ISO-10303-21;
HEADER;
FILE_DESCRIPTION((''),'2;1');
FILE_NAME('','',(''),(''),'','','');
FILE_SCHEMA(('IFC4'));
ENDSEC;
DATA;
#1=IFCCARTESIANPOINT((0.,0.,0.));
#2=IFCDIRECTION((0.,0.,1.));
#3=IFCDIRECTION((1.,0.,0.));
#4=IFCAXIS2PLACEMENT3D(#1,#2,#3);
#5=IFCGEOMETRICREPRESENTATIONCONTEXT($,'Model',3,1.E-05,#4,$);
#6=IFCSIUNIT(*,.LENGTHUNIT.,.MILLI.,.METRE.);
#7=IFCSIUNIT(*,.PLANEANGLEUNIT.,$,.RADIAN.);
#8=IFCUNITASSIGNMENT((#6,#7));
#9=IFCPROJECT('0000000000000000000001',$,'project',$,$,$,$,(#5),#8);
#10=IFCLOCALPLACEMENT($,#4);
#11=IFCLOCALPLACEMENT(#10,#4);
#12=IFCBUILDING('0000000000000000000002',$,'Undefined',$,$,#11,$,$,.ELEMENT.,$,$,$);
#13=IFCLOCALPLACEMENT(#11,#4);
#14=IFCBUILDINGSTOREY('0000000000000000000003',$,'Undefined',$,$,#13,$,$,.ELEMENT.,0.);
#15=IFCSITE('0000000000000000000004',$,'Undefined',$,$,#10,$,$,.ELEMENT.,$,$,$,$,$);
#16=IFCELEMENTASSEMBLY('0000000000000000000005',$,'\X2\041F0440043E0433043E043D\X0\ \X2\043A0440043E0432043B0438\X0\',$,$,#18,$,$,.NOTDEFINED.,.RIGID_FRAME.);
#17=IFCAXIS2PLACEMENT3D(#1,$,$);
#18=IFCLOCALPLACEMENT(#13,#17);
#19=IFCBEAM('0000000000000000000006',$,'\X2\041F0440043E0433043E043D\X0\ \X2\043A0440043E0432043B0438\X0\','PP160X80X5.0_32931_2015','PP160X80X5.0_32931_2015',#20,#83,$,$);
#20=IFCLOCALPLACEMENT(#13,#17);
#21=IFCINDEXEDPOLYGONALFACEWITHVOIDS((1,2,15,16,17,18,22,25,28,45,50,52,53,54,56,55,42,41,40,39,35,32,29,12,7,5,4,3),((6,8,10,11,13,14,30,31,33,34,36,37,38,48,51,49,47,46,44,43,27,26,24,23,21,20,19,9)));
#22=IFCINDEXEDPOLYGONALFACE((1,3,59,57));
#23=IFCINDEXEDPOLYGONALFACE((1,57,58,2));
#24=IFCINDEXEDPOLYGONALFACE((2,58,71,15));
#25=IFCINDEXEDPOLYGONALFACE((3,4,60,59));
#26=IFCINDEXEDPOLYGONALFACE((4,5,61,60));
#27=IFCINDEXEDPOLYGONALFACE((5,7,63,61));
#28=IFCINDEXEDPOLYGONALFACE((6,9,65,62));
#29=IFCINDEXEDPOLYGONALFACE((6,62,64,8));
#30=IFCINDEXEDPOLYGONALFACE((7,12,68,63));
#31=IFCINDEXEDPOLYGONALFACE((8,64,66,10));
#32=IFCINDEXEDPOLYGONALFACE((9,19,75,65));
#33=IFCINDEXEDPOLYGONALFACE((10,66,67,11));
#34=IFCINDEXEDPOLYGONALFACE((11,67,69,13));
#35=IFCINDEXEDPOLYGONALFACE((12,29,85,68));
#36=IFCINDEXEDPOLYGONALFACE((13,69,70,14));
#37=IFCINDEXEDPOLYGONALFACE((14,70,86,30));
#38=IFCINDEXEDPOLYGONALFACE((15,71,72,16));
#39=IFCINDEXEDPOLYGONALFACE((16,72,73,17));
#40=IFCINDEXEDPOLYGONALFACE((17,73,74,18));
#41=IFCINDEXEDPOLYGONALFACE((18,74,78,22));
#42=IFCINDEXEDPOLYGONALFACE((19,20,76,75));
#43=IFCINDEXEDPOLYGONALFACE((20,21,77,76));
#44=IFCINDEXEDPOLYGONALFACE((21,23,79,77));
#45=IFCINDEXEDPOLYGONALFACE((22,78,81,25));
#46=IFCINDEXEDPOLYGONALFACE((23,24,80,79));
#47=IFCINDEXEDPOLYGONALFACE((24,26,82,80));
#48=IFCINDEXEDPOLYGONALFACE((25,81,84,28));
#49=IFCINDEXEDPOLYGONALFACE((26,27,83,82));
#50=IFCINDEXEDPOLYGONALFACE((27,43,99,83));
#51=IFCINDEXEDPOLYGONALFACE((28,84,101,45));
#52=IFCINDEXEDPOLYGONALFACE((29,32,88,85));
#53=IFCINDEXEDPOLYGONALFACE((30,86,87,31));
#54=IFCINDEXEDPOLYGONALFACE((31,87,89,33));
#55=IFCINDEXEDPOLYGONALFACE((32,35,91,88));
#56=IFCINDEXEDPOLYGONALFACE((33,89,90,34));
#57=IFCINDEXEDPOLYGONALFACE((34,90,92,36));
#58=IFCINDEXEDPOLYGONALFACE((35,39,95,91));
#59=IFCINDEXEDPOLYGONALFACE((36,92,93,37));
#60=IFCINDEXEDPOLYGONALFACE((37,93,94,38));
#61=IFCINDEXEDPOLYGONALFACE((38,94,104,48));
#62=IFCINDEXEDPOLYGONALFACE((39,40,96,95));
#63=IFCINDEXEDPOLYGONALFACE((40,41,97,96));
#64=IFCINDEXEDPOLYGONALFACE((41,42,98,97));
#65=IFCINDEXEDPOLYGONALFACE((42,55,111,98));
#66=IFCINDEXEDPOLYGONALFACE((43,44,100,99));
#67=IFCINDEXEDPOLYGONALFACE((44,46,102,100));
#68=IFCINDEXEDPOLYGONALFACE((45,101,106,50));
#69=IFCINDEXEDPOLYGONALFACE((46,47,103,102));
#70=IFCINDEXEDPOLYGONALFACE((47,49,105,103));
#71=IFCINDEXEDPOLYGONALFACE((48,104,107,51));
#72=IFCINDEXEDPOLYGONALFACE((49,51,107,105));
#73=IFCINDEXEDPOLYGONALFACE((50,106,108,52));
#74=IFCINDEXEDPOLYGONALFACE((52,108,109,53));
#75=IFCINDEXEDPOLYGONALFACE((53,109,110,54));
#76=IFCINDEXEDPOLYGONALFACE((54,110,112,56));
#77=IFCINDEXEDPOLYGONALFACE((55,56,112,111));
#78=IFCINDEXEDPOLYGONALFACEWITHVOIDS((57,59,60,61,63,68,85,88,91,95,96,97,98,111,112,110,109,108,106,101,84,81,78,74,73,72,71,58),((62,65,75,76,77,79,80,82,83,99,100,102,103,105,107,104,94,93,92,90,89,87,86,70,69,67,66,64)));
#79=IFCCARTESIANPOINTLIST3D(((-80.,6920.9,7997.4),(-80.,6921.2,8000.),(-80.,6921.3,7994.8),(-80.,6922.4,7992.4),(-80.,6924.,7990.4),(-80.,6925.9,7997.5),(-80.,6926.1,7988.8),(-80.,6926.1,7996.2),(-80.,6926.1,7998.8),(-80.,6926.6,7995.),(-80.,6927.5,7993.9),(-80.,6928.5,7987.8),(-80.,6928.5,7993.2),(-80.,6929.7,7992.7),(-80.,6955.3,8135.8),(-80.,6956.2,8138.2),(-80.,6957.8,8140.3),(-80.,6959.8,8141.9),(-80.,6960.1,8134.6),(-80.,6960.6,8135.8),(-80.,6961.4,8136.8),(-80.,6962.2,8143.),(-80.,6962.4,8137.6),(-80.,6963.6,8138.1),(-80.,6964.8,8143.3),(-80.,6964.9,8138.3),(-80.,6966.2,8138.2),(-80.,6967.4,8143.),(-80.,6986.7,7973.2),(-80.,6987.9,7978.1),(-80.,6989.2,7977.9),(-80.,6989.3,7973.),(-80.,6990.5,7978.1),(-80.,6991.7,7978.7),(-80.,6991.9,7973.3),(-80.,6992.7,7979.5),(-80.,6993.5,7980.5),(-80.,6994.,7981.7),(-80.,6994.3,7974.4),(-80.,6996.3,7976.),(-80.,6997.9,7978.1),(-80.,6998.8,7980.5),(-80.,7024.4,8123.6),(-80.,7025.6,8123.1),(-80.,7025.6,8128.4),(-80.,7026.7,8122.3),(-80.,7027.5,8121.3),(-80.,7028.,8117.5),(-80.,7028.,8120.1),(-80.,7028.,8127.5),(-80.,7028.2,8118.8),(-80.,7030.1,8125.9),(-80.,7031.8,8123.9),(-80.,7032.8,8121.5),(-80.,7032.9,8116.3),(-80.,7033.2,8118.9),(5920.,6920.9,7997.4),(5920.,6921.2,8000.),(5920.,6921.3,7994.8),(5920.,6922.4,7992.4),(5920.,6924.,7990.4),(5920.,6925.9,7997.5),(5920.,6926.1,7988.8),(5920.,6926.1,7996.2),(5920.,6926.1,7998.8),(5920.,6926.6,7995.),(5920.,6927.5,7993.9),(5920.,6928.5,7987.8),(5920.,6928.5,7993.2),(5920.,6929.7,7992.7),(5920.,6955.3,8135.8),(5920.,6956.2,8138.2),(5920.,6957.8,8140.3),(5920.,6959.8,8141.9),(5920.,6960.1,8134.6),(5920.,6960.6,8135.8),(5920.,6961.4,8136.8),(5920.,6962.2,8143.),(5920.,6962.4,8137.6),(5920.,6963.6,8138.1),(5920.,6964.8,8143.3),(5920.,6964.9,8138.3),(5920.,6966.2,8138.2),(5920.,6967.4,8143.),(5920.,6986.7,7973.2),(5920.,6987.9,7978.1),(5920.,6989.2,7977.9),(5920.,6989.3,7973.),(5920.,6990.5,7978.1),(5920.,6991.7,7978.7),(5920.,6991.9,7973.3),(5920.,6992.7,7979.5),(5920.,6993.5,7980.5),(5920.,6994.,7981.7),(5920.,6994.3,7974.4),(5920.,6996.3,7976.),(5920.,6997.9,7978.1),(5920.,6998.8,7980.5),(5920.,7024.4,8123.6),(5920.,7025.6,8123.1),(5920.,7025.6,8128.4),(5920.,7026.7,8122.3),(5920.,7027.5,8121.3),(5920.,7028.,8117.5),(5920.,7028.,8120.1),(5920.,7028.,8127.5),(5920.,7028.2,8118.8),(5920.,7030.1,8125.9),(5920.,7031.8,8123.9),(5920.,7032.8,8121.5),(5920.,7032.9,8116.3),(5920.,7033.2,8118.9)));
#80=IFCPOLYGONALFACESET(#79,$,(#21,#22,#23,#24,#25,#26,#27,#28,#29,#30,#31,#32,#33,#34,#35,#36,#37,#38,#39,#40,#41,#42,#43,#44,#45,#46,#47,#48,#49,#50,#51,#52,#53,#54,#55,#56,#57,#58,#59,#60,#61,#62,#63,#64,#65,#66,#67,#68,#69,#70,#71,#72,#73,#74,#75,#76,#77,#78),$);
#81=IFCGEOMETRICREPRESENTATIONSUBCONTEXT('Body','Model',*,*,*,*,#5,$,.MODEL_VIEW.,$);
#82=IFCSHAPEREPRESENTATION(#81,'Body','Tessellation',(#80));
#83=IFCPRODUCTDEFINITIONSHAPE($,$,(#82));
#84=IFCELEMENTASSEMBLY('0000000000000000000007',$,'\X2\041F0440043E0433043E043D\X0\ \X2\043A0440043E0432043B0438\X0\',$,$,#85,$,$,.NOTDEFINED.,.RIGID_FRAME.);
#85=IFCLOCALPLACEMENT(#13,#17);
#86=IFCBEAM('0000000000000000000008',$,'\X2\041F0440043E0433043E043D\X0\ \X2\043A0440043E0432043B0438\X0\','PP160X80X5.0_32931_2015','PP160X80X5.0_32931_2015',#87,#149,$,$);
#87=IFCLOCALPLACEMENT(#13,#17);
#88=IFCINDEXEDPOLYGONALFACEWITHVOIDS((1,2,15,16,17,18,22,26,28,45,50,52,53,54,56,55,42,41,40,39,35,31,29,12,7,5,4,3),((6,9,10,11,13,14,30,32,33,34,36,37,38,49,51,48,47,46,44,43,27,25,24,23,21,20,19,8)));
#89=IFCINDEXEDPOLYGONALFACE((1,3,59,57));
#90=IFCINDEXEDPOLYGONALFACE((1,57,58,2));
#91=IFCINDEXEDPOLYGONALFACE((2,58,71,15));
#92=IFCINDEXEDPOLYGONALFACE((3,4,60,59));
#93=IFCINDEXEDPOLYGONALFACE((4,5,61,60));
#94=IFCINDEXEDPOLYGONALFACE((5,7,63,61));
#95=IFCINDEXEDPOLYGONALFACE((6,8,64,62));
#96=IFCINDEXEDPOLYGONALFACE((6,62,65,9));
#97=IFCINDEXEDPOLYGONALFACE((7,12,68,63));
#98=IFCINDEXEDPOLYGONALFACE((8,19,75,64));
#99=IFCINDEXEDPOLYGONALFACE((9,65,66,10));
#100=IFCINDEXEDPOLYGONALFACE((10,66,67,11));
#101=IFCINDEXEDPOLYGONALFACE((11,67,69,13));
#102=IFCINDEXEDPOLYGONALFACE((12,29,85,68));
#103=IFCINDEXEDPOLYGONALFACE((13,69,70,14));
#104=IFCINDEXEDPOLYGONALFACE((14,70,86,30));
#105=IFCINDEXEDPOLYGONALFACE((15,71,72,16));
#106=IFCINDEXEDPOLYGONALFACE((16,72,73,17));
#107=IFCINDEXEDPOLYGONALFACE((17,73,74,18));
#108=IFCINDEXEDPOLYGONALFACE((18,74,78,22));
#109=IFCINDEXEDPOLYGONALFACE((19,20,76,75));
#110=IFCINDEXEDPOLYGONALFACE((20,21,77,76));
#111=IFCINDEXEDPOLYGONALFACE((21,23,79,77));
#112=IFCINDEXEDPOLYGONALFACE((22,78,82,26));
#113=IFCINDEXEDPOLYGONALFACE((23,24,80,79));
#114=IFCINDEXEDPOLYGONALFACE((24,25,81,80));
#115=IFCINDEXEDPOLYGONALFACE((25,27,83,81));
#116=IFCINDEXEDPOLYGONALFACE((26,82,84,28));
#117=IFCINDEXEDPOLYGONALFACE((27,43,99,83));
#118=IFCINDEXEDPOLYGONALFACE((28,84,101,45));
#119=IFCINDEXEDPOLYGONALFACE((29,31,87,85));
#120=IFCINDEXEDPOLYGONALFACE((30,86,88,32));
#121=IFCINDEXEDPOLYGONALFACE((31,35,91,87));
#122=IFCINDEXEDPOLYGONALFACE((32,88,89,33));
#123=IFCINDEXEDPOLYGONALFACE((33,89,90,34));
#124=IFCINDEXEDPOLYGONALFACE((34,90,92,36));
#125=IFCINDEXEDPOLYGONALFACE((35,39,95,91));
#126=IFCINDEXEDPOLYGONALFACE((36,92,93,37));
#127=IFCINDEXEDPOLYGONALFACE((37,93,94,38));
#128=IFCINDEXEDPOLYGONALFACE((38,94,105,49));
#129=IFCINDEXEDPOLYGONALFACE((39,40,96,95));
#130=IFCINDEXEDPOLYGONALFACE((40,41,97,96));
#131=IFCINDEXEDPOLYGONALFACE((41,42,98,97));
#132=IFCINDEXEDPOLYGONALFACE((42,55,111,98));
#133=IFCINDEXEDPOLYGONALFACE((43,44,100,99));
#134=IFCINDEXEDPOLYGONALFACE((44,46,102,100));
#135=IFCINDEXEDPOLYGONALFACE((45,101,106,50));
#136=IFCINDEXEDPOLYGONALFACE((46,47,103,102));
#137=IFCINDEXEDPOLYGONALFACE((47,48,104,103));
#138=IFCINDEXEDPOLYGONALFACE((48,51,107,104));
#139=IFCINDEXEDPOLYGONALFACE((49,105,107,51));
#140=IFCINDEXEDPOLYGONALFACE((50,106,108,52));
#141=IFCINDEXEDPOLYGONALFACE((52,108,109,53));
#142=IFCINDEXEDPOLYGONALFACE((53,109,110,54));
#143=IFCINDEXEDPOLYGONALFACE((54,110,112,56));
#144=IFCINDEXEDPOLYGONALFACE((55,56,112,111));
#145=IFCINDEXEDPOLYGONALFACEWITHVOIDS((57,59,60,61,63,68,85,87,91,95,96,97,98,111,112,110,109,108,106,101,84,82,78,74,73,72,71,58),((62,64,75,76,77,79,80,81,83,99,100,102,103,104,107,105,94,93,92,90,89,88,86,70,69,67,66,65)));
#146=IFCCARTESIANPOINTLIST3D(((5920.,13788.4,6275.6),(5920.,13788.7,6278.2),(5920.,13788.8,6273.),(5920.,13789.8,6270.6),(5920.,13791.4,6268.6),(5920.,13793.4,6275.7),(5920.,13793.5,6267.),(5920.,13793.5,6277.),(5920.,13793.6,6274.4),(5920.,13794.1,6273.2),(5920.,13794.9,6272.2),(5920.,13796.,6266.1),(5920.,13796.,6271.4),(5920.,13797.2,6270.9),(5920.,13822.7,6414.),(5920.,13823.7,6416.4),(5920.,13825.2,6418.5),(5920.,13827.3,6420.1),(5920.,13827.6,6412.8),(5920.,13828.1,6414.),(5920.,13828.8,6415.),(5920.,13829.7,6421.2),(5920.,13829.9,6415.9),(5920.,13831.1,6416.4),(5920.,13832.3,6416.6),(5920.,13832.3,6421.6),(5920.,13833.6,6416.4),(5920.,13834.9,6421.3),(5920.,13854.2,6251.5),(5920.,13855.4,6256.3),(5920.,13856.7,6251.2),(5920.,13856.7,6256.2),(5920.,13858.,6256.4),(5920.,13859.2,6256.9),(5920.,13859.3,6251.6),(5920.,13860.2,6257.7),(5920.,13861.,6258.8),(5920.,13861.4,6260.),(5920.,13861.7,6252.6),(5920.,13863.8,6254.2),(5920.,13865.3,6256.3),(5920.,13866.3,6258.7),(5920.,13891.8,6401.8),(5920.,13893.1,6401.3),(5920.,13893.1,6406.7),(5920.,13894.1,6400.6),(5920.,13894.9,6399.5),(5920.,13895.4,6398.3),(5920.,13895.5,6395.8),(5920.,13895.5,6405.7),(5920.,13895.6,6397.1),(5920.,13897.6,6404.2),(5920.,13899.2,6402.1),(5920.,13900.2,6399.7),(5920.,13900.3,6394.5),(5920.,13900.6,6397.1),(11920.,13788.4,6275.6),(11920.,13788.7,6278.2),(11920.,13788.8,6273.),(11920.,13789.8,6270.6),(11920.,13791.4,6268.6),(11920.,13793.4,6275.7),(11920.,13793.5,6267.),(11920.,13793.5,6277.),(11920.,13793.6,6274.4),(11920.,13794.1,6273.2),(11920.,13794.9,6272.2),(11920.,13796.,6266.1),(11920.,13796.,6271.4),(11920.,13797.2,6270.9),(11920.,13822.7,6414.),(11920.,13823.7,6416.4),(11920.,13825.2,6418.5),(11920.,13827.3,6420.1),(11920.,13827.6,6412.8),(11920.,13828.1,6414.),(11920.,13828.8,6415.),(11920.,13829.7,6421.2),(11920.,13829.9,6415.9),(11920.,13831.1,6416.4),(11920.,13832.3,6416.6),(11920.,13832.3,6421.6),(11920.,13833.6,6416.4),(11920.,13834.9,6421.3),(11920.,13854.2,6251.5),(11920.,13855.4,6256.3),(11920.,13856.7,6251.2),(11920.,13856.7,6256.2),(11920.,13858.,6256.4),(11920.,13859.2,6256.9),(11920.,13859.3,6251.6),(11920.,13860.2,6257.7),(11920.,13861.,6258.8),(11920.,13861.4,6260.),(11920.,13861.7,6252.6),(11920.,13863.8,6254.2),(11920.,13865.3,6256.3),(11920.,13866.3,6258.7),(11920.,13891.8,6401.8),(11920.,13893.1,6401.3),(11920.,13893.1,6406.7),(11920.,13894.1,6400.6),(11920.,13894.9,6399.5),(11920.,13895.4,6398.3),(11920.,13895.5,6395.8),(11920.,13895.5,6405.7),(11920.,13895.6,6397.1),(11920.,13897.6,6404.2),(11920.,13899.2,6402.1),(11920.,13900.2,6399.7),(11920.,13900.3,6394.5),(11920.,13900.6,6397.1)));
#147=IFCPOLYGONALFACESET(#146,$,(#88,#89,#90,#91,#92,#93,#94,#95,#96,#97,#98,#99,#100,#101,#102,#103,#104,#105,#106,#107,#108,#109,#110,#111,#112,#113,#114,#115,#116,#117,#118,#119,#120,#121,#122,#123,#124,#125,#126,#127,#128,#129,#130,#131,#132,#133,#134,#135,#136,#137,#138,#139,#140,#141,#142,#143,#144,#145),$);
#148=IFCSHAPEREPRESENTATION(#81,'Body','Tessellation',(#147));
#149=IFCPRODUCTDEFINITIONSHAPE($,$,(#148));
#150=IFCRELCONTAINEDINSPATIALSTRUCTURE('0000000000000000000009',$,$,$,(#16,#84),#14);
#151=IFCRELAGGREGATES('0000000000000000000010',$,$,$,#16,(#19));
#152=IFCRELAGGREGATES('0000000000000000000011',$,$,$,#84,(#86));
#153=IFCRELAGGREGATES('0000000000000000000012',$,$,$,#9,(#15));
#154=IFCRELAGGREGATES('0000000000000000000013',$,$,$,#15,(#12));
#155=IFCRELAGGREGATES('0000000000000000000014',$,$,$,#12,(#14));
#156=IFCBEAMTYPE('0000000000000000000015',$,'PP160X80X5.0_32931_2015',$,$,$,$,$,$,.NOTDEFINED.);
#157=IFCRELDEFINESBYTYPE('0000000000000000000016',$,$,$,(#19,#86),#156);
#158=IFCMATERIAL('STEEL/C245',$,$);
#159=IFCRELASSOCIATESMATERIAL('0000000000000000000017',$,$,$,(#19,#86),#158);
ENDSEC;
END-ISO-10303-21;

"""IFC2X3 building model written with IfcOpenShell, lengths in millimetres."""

from ifc_helpers import new_model, si_unit, frame, origin_with_axes, origin_2d_with_axis, place, context, subcontext, project, spatial, hollow_rectangle, extrude, material, type_object, element, aggregate, save


model = new_model("IFC2X3")

# Units and contexts
model_context = context("Model", 3, precision=1e-05, world=origin_with_axes())
body_context = subcontext(model_context, "Body", "Model", "MODEL_VIEW")
ifc_project = project(units=[si_unit("LENGTHUNIT", "METRE", prefix="MILLI"), si_unit("PLANEANGLEUNIT", "RADIAN")], contexts=[model_context])

# Site, building, storey
site_placement = place(None, origin_with_axes())
site = spatial("IfcSite", under=ifc_project, at=site_placement, Name="Undefined", CompositionType="ELEMENT")
building_placement = place(site_placement, origin_with_axes())
building = spatial("IfcBuilding", under=site, at=building_placement, Name="Undefined", CompositionType="ELEMENT")
storey_placement = place(building_placement, origin_with_axes())
storey = spatial("IfcBuildingStorey", under=building, at=storey_placement, Name="Undefined", CompositionType="ELEMENT", Elevation=0.0)

# Shared definitions
ifc_material = material(Name="STEEL/C245")

# Element assemblies, beams
beam_type_1 = type_object("IfcBeamType", Name="PP160X80X5.0_32931_2015", PredefinedType="NOTDEFINED")
assembly_1_placement = place(storey_placement, origin_with_axes())
assembly_1 = element("IfcElementAssembly", 1, at=assembly_1_placement, inside=storey, Name="Прогон кровли", AssemblyPlace="NOTDEFINED", PredefinedType="RIGID_FRAME")
beam_1_placement = place(assembly_1_placement, frame((-80.0, 6977.1, 8058.1), z_axis=(0.0, 0.243188, 0.969979), x_axis=(1.0, 0.0, 0.0)))
beam_1 = element("IfcBeam", 2, at=beam_1_placement, type_object=beam_type_1, material=ifc_material, Name="Прогон кровли", Description="PP160X80X5.0_32931_2015", ObjectType="PP160X80X5.0_32931_2015", context=body_context, shape_type="SweptSolid", body=[
    extrude(hollow_rectangle(XDim=80.0, YDim=160.0, WallThickness=5.0, InnerFilletRadius=5.0, OuterFilletRadius=10.0, at=origin_2d_with_axis()), frame((6000.0, 0.0, 0.0), z_axis=(-1.0, 0.0, 0.0), x_axis=(0.0, -1.0, 0.0)), (0.0, 0.0, 1.0), 6000.0),
])
aggregate(assembly_1, [beam_1])
assembly_2_placement = place(storey_placement, origin_with_axes())
assembly_2 = element("IfcElementAssembly", 3, at=assembly_2_placement, inside=storey, Name="Прогон кровли", AssemblyPlace="NOTDEFINED", PredefinedType="RIGID_FRAME")
beam_2_placement = place(assembly_2_placement, frame((5920.0, 13844.5, 6336.4), z_axis=(0.0, 0.243188, 0.969979), x_axis=(1.0, 0.0, 0.0)))
beam_2 = element("IfcBeam", 4, at=beam_2_placement, type_object=beam_type_1, material=ifc_material, Name="Прогон кровли", Description="PP160X80X5.0_32931_2015", ObjectType="PP160X80X5.0_32931_2015", context=body_context, shape_type="SweptSolid", body=[
    extrude(hollow_rectangle(XDim=80.0, YDim=160.0, WallThickness=5.0, InnerFilletRadius=5.0, OuterFilletRadius=10.0, at=origin_2d_with_axis()), frame((6000.0, 0.0, 0.0), z_axis=(-1.0, 0.0, 0.0), x_axis=(0.0, -1.0, 0.0)), (0.0, 0.0, 1.0), 6000.0),
])
aggregate(assembly_2, [beam_2])

save(model, "model.ifc")
